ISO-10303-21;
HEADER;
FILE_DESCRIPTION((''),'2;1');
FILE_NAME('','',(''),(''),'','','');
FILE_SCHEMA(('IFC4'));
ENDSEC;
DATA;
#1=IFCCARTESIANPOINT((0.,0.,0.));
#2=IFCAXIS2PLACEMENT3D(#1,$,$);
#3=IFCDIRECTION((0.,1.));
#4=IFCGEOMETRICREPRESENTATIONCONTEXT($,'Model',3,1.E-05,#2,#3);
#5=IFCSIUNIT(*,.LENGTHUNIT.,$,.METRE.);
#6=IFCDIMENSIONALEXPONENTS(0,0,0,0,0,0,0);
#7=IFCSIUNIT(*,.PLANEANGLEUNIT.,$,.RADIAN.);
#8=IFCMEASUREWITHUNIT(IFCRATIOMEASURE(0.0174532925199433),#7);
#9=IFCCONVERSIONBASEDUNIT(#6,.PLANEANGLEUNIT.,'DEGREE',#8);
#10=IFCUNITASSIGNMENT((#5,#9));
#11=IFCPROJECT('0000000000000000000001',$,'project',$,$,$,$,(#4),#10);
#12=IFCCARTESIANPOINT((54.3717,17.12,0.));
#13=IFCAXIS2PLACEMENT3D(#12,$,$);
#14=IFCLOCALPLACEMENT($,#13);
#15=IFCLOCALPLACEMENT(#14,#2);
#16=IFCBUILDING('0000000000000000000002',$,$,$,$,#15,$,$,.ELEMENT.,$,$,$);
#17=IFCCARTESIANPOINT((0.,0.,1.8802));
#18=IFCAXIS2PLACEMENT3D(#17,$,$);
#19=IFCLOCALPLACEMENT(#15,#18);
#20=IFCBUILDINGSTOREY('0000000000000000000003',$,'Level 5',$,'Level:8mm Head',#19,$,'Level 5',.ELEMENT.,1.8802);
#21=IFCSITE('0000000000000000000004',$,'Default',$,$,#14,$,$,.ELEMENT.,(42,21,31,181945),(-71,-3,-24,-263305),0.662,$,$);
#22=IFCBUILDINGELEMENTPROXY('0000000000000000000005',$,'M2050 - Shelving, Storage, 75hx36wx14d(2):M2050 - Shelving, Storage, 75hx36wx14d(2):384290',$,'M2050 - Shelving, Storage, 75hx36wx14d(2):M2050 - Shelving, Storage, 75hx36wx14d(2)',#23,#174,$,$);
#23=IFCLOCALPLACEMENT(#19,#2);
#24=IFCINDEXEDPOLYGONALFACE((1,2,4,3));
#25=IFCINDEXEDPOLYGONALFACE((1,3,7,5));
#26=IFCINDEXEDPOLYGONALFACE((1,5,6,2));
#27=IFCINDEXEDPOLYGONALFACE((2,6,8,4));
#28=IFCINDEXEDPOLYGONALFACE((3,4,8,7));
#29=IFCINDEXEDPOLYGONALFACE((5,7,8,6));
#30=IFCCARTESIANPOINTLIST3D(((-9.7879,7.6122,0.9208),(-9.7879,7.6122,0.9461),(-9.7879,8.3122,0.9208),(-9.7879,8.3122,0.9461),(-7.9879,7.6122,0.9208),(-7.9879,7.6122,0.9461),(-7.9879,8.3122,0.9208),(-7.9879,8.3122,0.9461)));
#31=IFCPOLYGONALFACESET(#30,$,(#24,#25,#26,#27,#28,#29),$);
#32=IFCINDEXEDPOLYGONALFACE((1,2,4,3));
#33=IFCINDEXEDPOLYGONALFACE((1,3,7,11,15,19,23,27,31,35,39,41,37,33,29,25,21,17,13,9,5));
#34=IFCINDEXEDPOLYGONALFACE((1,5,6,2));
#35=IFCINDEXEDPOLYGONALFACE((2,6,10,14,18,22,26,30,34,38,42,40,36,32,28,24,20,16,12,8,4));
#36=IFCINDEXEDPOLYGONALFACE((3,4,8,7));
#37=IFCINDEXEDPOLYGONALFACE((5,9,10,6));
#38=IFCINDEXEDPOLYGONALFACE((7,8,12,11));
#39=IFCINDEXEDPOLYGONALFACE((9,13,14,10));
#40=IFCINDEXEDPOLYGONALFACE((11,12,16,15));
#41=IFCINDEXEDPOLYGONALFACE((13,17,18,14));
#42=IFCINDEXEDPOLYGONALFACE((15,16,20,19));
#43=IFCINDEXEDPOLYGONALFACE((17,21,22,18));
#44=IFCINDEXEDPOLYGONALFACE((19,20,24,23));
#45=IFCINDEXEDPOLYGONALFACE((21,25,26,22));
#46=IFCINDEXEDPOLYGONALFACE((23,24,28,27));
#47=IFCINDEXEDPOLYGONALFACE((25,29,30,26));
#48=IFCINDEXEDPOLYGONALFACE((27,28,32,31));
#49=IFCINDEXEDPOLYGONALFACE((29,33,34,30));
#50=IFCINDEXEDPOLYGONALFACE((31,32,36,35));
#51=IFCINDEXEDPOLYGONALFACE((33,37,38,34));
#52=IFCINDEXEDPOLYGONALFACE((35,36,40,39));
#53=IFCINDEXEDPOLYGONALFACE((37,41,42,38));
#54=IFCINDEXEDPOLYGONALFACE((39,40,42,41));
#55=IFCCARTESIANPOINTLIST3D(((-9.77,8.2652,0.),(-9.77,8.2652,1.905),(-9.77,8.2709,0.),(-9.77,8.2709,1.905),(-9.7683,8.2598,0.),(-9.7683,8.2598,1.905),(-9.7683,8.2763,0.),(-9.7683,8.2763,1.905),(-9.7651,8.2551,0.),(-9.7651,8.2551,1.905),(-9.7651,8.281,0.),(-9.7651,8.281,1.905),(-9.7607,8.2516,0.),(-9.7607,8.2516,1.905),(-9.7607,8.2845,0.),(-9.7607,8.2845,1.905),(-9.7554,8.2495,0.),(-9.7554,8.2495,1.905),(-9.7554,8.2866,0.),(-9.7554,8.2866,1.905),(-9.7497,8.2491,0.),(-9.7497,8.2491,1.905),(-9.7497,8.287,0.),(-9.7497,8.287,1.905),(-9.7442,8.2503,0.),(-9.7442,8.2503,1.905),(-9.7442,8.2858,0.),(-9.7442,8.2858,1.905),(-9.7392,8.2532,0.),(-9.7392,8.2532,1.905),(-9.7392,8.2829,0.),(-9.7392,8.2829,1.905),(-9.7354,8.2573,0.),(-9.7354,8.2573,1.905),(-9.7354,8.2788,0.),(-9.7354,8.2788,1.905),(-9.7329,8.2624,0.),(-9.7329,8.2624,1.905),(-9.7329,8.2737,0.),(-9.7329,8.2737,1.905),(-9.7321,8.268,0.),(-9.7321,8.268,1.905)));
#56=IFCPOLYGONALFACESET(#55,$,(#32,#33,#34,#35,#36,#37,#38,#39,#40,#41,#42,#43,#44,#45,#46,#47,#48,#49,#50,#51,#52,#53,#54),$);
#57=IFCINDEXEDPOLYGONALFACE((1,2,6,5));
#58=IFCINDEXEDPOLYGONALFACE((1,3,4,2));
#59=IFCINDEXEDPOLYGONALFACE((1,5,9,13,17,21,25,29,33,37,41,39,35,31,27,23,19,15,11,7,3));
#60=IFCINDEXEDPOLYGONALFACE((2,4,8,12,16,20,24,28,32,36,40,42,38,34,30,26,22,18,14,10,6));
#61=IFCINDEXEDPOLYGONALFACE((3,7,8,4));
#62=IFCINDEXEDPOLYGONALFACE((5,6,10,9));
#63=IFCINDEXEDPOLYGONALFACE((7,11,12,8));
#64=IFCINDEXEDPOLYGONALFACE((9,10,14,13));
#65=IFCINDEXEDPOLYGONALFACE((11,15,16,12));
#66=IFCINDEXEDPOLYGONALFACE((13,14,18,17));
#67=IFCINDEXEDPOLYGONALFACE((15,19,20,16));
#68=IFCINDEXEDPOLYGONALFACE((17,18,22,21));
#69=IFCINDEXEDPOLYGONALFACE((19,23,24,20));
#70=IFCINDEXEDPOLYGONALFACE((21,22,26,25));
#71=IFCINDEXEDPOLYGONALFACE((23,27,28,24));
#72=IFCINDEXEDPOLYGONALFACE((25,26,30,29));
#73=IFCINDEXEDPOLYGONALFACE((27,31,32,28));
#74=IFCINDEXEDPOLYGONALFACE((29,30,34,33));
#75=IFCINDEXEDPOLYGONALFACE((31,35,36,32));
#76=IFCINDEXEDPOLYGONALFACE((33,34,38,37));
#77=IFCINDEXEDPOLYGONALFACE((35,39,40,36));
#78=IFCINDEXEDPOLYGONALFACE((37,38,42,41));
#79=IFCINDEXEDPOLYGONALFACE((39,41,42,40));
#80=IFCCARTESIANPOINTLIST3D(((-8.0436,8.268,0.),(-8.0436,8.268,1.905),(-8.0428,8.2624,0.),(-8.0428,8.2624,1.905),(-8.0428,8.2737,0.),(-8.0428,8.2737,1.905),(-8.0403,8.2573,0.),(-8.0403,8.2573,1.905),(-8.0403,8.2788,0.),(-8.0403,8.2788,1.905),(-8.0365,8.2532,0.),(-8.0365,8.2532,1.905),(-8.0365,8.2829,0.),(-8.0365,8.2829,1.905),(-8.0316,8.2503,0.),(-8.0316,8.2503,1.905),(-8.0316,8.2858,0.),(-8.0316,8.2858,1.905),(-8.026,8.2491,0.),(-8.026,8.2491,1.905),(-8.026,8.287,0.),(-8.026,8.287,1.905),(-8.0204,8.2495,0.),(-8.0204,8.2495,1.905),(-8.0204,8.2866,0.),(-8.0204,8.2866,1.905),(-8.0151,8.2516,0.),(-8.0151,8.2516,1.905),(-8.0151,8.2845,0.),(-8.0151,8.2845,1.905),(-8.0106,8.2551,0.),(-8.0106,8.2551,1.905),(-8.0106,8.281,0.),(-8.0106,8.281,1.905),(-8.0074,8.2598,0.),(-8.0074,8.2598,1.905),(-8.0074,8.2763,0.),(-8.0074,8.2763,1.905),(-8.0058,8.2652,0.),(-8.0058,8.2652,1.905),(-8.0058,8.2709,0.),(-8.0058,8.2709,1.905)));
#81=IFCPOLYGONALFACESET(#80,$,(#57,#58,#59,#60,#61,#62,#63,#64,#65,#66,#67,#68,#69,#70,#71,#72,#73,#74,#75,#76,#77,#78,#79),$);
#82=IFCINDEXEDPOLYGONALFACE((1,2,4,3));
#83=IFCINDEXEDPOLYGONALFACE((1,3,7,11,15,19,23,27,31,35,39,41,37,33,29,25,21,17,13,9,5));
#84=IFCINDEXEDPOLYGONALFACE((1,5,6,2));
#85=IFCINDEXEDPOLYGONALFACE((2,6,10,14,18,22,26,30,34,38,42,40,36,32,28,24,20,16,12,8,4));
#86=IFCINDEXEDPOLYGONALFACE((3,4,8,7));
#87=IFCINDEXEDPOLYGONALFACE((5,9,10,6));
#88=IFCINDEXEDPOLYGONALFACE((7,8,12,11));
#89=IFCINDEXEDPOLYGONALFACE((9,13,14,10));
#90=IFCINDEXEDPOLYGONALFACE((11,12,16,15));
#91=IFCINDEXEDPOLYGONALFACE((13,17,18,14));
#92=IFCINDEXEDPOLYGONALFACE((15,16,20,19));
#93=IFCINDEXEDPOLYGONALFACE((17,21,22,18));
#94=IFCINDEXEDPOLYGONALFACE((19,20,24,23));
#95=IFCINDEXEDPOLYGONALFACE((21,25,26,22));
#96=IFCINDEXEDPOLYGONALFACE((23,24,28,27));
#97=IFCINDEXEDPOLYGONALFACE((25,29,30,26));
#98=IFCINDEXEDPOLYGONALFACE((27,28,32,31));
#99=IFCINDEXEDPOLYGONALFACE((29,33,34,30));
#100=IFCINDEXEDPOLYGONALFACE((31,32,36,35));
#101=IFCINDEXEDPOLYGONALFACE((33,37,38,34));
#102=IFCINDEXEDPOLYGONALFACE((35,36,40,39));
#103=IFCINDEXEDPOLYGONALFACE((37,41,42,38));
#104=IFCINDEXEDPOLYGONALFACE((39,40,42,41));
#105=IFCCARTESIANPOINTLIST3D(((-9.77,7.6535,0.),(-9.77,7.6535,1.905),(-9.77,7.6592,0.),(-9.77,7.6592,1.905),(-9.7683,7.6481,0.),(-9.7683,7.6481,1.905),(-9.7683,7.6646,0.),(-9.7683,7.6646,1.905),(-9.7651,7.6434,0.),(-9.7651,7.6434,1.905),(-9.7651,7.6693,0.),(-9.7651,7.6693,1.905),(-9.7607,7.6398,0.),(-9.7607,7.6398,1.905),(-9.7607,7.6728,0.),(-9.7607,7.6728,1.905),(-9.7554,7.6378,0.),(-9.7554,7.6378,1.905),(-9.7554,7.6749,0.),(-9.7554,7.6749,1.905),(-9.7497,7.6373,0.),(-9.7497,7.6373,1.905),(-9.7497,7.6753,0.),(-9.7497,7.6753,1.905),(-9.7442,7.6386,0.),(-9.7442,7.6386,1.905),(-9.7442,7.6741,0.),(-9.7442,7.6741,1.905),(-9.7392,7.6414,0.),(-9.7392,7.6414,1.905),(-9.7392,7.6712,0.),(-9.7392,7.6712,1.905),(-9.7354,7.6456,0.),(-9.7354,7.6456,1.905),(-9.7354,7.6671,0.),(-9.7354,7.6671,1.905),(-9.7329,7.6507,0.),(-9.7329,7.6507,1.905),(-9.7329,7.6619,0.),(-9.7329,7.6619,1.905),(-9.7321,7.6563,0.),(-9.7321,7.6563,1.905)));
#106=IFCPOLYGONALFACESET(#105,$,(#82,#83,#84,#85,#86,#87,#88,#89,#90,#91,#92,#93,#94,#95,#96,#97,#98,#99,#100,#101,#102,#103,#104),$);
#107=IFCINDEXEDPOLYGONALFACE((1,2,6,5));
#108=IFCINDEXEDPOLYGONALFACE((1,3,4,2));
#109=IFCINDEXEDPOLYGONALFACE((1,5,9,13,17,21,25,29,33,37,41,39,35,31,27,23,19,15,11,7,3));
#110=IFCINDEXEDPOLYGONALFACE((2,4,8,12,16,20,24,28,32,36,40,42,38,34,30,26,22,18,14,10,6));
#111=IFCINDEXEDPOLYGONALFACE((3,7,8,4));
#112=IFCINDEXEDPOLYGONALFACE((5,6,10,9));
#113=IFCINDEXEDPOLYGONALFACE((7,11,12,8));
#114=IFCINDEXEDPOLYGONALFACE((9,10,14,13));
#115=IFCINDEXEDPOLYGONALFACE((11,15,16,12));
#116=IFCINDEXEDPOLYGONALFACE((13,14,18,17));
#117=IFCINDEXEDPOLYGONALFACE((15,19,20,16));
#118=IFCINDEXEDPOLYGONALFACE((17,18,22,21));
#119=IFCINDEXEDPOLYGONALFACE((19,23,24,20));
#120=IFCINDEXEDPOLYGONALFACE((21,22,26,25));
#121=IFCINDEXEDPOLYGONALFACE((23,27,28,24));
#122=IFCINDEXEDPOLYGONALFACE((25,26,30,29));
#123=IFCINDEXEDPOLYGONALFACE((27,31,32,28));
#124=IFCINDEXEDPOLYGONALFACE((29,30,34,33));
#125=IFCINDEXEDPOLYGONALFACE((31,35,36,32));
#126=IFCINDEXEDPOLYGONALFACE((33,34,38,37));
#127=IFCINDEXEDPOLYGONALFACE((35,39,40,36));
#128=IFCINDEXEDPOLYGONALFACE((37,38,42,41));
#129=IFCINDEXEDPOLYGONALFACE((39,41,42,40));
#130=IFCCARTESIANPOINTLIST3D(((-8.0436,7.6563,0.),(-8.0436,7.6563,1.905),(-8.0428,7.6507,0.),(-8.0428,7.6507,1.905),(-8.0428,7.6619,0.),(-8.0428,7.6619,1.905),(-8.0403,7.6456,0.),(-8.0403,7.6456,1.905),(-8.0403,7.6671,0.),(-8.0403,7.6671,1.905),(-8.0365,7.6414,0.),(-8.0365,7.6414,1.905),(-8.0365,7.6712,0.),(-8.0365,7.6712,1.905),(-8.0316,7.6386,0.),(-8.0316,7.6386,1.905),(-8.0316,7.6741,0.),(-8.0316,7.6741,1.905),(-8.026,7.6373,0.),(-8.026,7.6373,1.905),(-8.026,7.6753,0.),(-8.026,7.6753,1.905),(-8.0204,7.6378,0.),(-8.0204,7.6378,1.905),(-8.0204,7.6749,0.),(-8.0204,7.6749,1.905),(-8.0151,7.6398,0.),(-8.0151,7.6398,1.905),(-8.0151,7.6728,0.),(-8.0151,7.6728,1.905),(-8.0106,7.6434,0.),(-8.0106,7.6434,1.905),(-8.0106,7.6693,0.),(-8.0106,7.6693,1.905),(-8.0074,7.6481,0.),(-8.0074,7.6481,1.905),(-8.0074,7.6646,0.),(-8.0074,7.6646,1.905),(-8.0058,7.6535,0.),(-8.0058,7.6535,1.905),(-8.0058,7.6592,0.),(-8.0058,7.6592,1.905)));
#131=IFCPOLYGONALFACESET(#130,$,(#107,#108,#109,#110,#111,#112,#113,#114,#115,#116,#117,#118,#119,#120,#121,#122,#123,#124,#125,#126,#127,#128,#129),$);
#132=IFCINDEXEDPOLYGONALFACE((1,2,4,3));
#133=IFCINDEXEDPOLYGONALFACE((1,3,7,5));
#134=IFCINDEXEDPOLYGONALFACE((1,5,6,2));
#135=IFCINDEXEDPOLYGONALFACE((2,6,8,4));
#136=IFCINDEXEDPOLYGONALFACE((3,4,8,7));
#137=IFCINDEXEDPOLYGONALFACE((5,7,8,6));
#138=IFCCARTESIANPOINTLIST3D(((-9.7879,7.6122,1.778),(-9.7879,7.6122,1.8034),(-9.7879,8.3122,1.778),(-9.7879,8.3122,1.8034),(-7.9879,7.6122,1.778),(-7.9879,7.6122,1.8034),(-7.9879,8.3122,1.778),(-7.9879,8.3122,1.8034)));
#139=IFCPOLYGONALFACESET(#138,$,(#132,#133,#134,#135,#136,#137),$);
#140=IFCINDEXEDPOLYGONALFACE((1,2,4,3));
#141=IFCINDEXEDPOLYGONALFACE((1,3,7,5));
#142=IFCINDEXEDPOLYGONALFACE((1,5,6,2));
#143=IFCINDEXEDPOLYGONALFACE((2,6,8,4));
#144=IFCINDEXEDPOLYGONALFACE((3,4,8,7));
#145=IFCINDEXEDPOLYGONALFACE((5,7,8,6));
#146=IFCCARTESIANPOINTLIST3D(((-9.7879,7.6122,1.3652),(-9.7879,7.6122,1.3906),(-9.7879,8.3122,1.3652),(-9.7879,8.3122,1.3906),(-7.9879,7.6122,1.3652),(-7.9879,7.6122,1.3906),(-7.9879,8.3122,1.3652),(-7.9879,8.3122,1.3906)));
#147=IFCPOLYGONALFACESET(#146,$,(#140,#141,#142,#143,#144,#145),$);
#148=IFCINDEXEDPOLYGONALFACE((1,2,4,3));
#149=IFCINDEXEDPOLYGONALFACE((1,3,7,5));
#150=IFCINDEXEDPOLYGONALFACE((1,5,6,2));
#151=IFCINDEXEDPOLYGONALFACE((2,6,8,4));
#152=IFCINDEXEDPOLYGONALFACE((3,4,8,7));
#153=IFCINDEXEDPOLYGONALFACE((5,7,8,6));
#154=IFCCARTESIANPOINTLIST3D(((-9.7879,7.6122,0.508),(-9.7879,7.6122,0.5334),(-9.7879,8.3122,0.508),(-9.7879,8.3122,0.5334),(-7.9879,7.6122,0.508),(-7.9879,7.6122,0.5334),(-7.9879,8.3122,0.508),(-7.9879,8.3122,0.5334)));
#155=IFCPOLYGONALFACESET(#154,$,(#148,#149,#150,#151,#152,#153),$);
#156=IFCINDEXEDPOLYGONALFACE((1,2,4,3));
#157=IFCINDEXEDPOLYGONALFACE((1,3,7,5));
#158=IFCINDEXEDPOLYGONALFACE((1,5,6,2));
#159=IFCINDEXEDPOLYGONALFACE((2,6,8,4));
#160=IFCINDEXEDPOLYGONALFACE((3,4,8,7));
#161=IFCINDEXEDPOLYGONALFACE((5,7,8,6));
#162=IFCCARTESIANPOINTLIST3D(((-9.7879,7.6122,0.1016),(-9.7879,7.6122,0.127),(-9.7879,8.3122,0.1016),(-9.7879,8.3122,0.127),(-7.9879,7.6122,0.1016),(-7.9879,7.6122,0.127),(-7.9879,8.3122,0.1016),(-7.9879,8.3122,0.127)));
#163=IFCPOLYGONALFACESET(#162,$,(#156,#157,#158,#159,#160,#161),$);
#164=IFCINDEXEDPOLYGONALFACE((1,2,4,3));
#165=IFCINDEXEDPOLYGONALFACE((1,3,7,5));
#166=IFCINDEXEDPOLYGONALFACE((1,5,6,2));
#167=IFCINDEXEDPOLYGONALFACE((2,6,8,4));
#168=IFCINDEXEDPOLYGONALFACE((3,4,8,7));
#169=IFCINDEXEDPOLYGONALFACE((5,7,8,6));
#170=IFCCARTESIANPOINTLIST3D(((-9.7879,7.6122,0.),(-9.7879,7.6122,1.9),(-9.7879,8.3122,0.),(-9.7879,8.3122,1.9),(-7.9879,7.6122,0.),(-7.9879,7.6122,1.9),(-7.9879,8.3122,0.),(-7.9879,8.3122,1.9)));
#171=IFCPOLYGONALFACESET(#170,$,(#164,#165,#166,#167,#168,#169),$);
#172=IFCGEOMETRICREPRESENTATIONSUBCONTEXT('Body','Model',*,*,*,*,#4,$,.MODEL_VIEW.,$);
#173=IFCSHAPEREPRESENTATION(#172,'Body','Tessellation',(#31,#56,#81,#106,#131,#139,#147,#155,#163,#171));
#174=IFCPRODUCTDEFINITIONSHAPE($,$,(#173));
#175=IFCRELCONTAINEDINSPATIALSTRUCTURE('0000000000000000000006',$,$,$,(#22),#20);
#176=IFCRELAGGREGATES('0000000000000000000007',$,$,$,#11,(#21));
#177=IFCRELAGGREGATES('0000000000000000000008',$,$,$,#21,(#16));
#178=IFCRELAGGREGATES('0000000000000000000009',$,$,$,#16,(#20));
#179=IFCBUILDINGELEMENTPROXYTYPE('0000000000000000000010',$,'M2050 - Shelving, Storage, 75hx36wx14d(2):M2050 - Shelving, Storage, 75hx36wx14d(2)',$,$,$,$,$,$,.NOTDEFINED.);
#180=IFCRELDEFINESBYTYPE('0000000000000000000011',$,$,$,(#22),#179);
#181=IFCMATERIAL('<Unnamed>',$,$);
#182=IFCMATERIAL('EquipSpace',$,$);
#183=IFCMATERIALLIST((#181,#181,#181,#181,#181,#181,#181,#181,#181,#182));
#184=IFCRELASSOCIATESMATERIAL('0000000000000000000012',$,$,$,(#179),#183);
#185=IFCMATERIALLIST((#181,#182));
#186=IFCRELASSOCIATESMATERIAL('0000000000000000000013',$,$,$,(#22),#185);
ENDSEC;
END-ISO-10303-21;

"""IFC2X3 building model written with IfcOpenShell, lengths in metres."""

from ifc_helpers import new_model, entity, si_unit, converted_unit, direction, frame, frame_2d, origin, origin_2d_with_axis, place, context, subcontext, project, spatial, rectangle, circle, extrude, source, transform, mapped, material, material_list, type_object, type_shapes, element, save


model = new_model("IFC2X3")

# Units and contexts
model_context = context("Model", 3, precision=1e-05, world=origin(), true_north=direction((0.0, 1.0)))
body_context = subcontext(model_context, "Body", "Model", "MODEL_VIEW")
ifc_project = project(units=[si_unit("LENGTHUNIT", "METRE"), converted_unit("PLANEANGLEUNIT", "DEGREE", entity("IfcRatioMeasure", 0.0174532925199433), si_unit("PLANEANGLEUNIT", "RADIAN"), dimensions=[0, 0, 0, 0, 0, 0, 0])], contexts=[model_context])

# Site, building, storey
site_placement = place(None, frame((54.3717, 17.12, 0.0)))
site = spatial("IfcSite", under=ifc_project, at=site_placement, Name="Default", CompositionType="ELEMENT", RefLatitude=(42, 21, 31, 181945), RefLongitude=(-71, -3, -24, -263305), RefElevation=0.662)
building_placement = place(site_placement, origin())
building = spatial("IfcBuilding", under=site, at=building_placement, CompositionType="ELEMENT")
storey_placement = place(building_placement, frame((0.0, 0.0, 1.8802)))
storey = spatial("IfcBuildingStorey", under=building, at=storey_placement, Name="Level 5", ObjectType="Level:8mm Head", LongName="Level 5", CompositionType="ELEMENT", Elevation=1.8802)

# Building element proxy
ifc_material_1 = material(Name="<Unnamed>")
ifc_material_2 = material(Name="EquipSpace")
ifc_material_list_1 = material_list([ifc_material_1, ifc_material_1, ifc_material_1, ifc_material_1, ifc_material_1, ifc_material_1, ifc_material_1, ifc_material_1, ifc_material_1, ifc_material_2])
building_element_proxy_type = type_object("IfcBuildingElementProxyType", Name="M2050 - Shelving, Storage, 75hx36wx14d(2):M2050 - Shelving, Storage, 75hx36wx14d(2)", PredefinedType="NOTDEFINED", material=ifc_material_list_1)
shared_shape = source(origin(), body_context, "Body", "SweptSolid", [
    extrude(rectangle(XDim=1.8, YDim=0.7, at=origin_2d_with_axis()), frame((0.0, 0.0, 0.9207), z_axis=(0.0, 0.0, 1.0), x_axis=(-1.0, 0.0, 0.0)), (0.0, 0.0, 1.0), 0.0254),
    extrude(circle(Radius=0.0191, at=origin_2d_with_axis()), frame((0.8633, -0.3059, 0.0), z_axis=(0.0, 0.0, 1.0), x_axis=(-1.0, 0.0, 0.0)), (0.0, 0.0, 1.0), 1.905),
    extrude(circle(Radius=0.0191, at=origin_2d_with_axis()), frame((-0.8633, -0.3059, 0.0)), (0.0, 0.0, 1.0), 1.905),
    extrude(circle(Radius=0.0191, at=origin_2d_with_axis()), frame((0.8633, 0.3059, 0.0), z_axis=(0.0, 0.0, 1.0), x_axis=(-1.0, 0.0, 0.0)), (0.0, 0.0, 1.0), 1.905),
    extrude(circle(Radius=0.0191, at=origin_2d_with_axis()), frame((-0.8633, 0.3059, 0.0)), (0.0, 0.0, 1.0), 1.905),
    extrude(rectangle(XDim=1.8, YDim=0.7, at=origin_2d_with_axis()), frame((0.0, 0.0, 1.778), z_axis=(0.0, 0.0, 1.0), x_axis=(-1.0, 0.0, 0.0)), (0.0, 0.0, 1.0), 0.0254),
    extrude(rectangle(XDim=1.8, YDim=0.7, at=origin_2d_with_axis()), frame((0.0, 0.0, 1.3653), z_axis=(0.0, 0.0, 1.0), x_axis=(-1.0, 0.0, 0.0)), (0.0, 0.0, 1.0), 0.0254),
    extrude(rectangle(XDim=1.8, YDim=0.7, at=origin_2d_with_axis()), frame((0.0, 0.0, 0.508), z_axis=(0.0, 0.0, 1.0), x_axis=(-1.0, 0.0, 0.0)), (0.0, 0.0, 1.0), 0.0254),
    extrude(rectangle(XDim=1.8, YDim=0.7, at=origin_2d_with_axis()), frame((0.0, 0.0, 0.1016), z_axis=(0.0, 0.0, 1.0), x_axis=(-1.0, 0.0, 0.0)), (0.0, 0.0, 1.0), 0.0254),
    extrude(rectangle(XDim=0.7, YDim=1.8, at=frame_2d((0.0, 0.18), x_axis=(1.0, 0.0))), frame((-0.18, 0.0, 0.0), z_axis=(0.0, 0.0, 1.0), x_axis=(0.0, -1.0, 0.0)), (0.0, 0.0, 1.0), 1.9),
])
type_shapes(building_element_proxy_type, [shared_shape])
ifc_material_list_2 = material_list([ifc_material_1, ifc_material_2])
proxy_1_placement = place(storey_placement, frame((-8.8879, 7.9622, 0.0), z_axis=(0.0, 0.0, 1.0), x_axis=(-1.0, 0.0, 0.0)))
element("IfcBuildingElementProxy", 1, at=proxy_1_placement, inside=storey, type_object=building_element_proxy_type, material=ifc_material_list_2, Name="M2050 - Shelving, Storage, 75hx36wx14d(2):M2050 - Shelving, Storage, 75hx36wx14d(2):384290", ObjectType="M2050 - Shelving, Storage, 75hx36wx14d(2):M2050 - Shelving, Storage, 75hx36wx14d(2)", context=body_context, shape_type="MappedRepresentation", body=[
    mapped(shared_shape, transform((0.0, 0.0, 0.0), scale=1.0)),
])

save(model, "model.ifc")
